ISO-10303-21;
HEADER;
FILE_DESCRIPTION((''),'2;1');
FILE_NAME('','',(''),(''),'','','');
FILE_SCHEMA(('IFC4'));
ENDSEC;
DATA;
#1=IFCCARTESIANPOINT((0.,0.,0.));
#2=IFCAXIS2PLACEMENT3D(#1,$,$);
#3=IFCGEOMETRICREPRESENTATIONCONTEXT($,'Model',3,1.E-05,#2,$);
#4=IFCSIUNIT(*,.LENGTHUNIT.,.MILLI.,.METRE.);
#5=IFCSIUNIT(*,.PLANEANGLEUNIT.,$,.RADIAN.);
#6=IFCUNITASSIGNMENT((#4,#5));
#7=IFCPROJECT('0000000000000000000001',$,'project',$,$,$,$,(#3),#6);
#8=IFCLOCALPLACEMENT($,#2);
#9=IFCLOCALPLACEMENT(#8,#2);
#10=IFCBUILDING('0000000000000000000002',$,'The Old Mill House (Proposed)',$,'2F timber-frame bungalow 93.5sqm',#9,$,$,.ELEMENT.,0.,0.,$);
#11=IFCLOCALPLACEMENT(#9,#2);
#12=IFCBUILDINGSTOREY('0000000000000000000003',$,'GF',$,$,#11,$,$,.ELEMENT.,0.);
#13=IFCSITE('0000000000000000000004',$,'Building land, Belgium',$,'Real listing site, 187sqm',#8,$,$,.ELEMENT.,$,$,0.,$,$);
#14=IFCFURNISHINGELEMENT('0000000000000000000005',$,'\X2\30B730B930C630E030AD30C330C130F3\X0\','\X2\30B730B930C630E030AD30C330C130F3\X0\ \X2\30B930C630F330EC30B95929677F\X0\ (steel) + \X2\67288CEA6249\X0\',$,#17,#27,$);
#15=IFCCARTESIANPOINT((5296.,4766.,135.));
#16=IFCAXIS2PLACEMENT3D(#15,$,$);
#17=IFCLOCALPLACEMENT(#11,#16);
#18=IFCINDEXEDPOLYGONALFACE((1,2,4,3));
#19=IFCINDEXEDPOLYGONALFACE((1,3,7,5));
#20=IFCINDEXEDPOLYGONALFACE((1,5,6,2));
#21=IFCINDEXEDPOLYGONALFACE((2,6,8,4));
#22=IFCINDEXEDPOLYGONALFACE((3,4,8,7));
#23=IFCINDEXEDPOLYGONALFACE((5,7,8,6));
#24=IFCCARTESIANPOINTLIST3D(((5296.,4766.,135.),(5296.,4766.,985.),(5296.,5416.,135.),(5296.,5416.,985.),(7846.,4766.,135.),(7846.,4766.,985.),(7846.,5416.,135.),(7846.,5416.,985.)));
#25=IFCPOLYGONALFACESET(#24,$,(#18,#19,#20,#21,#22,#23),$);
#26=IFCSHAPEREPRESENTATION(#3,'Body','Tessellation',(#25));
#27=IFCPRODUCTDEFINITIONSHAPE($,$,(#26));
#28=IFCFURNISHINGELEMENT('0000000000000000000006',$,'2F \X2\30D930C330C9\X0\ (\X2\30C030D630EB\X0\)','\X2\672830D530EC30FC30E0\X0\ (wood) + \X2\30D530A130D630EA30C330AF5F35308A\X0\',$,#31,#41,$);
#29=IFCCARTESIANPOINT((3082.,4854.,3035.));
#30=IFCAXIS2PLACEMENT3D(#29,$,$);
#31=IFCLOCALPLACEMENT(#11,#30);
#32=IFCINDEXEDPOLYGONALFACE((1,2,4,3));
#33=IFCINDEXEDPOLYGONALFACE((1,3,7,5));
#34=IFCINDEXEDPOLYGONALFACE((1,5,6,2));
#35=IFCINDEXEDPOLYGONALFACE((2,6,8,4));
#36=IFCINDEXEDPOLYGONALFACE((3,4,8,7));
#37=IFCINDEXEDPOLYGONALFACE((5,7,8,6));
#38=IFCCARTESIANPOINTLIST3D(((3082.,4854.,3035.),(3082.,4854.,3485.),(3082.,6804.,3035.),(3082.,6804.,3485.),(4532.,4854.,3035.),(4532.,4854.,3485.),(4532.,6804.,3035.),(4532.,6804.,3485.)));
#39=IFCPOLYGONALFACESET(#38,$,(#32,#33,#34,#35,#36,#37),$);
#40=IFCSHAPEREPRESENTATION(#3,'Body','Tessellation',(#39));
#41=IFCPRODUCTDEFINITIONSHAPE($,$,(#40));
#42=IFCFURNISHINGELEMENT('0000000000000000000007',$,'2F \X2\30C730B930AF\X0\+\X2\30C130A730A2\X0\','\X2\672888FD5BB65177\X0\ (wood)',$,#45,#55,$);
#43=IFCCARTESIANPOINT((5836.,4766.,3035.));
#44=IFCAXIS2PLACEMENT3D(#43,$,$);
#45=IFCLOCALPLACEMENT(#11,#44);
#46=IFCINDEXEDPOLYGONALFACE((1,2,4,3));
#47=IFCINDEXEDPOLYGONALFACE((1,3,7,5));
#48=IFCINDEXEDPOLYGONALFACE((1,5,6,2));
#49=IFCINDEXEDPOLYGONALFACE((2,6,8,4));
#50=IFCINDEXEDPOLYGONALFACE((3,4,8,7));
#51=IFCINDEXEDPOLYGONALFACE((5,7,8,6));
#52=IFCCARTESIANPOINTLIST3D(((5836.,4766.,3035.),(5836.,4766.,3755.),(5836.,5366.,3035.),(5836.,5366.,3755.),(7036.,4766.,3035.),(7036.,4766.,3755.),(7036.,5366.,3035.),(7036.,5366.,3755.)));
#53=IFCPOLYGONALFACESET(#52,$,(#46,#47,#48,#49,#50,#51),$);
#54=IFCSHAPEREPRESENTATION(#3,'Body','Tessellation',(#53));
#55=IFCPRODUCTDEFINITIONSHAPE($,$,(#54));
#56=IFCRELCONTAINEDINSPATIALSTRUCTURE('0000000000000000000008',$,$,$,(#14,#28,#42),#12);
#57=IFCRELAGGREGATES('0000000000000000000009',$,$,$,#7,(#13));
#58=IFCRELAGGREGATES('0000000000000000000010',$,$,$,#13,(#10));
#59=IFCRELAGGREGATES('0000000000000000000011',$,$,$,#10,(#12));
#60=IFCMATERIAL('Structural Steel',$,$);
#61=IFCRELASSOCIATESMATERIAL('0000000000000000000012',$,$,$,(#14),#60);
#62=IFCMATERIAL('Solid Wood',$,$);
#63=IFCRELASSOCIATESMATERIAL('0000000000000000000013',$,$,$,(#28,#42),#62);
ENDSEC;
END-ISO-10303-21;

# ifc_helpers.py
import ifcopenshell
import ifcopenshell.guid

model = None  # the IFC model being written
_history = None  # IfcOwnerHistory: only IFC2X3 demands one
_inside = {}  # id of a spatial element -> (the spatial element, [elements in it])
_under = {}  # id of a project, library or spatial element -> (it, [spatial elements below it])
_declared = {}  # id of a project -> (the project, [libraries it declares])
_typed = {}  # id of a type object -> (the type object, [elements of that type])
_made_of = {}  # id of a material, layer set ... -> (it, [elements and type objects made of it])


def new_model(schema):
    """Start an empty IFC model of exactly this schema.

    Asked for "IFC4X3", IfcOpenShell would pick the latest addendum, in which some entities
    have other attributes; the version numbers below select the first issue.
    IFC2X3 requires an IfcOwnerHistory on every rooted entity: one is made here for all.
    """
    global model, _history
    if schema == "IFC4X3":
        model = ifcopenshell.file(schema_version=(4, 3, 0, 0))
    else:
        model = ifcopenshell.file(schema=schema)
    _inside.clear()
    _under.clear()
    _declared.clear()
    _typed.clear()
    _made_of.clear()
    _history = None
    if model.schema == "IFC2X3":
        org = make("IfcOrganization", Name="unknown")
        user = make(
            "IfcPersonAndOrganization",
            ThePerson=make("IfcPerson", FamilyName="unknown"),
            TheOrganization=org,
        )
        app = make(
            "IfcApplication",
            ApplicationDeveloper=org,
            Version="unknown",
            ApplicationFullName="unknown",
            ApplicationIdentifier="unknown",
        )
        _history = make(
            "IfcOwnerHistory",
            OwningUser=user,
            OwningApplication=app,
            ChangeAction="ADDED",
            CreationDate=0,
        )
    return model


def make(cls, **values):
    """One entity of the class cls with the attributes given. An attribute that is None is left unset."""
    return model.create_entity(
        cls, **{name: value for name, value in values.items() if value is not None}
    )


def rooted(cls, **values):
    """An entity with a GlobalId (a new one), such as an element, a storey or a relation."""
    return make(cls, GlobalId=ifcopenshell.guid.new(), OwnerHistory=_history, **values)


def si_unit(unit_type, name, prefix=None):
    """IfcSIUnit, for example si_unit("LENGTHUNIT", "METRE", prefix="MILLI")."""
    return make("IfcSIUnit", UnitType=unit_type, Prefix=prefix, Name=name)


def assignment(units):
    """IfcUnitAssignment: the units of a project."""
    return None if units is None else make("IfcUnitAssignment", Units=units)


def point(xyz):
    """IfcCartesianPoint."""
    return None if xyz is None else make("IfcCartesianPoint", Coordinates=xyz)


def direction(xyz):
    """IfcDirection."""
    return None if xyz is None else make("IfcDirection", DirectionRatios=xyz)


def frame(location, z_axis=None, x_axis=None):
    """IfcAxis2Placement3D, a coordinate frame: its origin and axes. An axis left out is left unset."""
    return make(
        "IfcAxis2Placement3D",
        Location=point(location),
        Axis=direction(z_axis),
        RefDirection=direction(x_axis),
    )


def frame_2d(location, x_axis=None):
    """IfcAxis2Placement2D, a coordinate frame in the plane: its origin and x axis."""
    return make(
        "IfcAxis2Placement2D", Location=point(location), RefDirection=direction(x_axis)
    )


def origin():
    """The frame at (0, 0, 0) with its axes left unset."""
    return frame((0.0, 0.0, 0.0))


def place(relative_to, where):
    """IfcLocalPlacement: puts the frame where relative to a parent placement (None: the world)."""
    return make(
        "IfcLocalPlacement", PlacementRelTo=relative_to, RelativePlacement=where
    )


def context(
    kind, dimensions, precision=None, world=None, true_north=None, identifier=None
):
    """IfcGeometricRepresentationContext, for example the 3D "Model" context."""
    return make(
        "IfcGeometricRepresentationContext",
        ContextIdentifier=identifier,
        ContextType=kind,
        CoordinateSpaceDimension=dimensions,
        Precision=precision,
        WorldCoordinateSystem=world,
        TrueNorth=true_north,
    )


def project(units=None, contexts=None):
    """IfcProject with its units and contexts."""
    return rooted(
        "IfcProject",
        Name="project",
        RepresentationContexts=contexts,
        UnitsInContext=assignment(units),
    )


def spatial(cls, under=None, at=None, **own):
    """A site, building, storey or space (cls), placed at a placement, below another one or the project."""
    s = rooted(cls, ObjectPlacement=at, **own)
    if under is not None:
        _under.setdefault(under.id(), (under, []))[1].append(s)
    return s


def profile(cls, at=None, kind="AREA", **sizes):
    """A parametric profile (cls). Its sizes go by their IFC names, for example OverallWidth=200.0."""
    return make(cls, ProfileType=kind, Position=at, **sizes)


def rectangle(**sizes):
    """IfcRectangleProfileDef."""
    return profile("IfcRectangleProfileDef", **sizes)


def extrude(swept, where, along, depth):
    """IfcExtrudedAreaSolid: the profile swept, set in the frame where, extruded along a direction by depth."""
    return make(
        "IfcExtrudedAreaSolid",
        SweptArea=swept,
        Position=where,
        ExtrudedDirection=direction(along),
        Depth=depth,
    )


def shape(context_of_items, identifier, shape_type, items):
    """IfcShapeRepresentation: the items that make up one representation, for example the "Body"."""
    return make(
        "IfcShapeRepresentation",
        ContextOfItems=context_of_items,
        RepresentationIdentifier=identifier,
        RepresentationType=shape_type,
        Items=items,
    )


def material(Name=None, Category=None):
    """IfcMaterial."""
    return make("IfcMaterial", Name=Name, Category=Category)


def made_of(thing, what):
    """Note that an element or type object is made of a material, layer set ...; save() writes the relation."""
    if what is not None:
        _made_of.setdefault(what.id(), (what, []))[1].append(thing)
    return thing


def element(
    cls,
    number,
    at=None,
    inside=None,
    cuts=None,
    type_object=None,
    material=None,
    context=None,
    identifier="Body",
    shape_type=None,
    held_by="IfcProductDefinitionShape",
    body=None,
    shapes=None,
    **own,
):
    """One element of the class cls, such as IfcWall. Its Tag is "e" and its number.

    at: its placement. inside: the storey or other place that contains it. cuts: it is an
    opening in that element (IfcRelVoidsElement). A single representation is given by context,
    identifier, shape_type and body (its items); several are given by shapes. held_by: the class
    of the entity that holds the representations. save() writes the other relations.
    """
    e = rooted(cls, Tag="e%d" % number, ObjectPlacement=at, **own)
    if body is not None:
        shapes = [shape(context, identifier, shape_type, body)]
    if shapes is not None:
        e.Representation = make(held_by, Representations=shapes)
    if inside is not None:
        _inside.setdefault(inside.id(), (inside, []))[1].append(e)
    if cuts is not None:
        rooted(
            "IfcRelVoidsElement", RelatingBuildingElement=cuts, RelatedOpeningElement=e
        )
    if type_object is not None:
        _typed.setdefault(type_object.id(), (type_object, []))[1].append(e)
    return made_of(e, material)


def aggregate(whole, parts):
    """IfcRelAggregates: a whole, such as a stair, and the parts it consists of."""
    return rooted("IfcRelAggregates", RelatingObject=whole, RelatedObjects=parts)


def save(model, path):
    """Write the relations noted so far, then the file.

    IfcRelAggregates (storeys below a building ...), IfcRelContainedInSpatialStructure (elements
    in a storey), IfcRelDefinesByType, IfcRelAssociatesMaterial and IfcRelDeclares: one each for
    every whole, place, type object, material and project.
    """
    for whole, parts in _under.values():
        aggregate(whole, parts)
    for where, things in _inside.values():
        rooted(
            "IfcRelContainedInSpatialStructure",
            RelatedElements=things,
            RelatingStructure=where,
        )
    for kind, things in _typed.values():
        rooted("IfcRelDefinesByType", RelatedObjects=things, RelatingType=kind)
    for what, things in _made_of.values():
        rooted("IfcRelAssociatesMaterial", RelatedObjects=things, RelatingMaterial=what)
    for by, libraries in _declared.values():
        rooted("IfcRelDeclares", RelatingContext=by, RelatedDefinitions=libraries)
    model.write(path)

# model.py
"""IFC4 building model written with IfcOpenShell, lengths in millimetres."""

from ifc_helpers import new_model, si_unit, frame, frame_2d, origin, place, context, project, spatial, rectangle, extrude, material, element, save


model = new_model("IFC4")

# Units and contexts
model_context = context("Model", 3, precision=1e-05, world=origin())
ifc_project = project(units=[si_unit("LENGTHUNIT", "METRE", prefix="MILLI"), si_unit("PLANEANGLEUNIT", "RADIAN")], contexts=[model_context])

# Site, building, storey
site_placement = place(None, origin())
site = spatial("IfcSite", under=ifc_project, at=site_placement, Name="Building land, Belgium", ObjectType="Real listing site, 187sqm", CompositionType="ELEMENT", RefElevation=0.0)
building_placement = place(site_placement, origin())
building = spatial("IfcBuilding", under=site, at=building_placement, Name="The Old Mill House (Proposed)", ObjectType="2F timber-frame bungalow 93.5sqm", CompositionType="ELEMENT", ElevationOfRefHeight=0.0, ElevationOfTerrain=0.0)
storey_placement = place(building_placement, origin())
storey = spatial("IfcBuildingStorey", under=building, at=storey_placement, Name="GF", CompositionType="ELEMENT", Elevation=0.0)

# Shared definitions
ifc_material_1 = material(Name="Solid Wood")

# Shared definitions
ifc_material_2 = material(Name="Structural Steel")

# Furnishing elements
furnishing_1_placement = place(storey_placement, frame((5296.0, 4766.0, 135.0)))
element("IfcFurnishingElement", 1, at=furnishing_1_placement, inside=storey, material=ifc_material_2, Name="システムキッチン", Description="システムキッチン ステンレス天板 (steel) + 木質扉", context=model_context, shape_type="SweptSolid", body=[
    extrude(rectangle(XDim=2550.0, YDim=650.0, at=frame_2d((1275.0, 325.0))), frame((5296.0, 4766.0, 135.0)), (0.0, 0.0, 1.0), 850.0),
])
furnishing_2_placement = place(storey_placement, frame((3082.0, 4854.0, 3035.0)))
element("IfcFurnishingElement", 2, at=furnishing_2_placement, inside=storey, material=ifc_material_1, Name="2F ベッド (ダブル)", Description="木フレーム (wood) + ファブリック張り", context=model_context, shape_type="SweptSolid", body=[
    extrude(rectangle(XDim=1450.0, YDim=1950.0, at=frame_2d((725.0, 975.0))), frame((3082.0, 4854.0, 3035.0)), (0.0, 0.0, 1.0), 450.0),
])
furnishing_3_placement = place(storey_placement, frame((5836.0, 4766.0, 3035.0)))
element("IfcFurnishingElement", 3, at=furnishing_3_placement, inside=storey, material=ifc_material_1, Name="2F デスク+チェア", Description="木製家具 (wood)", context=model_context, shape_type="SweptSolid", body=[
    extrude(rectangle(XDim=1200.0, YDim=600.0, at=frame_2d((600.0, 300.0))), frame((5836.0, 4766.0, 3035.0)), (0.0, 0.0, 1.0), 720.0),
])

save(model, "model.ifc")
